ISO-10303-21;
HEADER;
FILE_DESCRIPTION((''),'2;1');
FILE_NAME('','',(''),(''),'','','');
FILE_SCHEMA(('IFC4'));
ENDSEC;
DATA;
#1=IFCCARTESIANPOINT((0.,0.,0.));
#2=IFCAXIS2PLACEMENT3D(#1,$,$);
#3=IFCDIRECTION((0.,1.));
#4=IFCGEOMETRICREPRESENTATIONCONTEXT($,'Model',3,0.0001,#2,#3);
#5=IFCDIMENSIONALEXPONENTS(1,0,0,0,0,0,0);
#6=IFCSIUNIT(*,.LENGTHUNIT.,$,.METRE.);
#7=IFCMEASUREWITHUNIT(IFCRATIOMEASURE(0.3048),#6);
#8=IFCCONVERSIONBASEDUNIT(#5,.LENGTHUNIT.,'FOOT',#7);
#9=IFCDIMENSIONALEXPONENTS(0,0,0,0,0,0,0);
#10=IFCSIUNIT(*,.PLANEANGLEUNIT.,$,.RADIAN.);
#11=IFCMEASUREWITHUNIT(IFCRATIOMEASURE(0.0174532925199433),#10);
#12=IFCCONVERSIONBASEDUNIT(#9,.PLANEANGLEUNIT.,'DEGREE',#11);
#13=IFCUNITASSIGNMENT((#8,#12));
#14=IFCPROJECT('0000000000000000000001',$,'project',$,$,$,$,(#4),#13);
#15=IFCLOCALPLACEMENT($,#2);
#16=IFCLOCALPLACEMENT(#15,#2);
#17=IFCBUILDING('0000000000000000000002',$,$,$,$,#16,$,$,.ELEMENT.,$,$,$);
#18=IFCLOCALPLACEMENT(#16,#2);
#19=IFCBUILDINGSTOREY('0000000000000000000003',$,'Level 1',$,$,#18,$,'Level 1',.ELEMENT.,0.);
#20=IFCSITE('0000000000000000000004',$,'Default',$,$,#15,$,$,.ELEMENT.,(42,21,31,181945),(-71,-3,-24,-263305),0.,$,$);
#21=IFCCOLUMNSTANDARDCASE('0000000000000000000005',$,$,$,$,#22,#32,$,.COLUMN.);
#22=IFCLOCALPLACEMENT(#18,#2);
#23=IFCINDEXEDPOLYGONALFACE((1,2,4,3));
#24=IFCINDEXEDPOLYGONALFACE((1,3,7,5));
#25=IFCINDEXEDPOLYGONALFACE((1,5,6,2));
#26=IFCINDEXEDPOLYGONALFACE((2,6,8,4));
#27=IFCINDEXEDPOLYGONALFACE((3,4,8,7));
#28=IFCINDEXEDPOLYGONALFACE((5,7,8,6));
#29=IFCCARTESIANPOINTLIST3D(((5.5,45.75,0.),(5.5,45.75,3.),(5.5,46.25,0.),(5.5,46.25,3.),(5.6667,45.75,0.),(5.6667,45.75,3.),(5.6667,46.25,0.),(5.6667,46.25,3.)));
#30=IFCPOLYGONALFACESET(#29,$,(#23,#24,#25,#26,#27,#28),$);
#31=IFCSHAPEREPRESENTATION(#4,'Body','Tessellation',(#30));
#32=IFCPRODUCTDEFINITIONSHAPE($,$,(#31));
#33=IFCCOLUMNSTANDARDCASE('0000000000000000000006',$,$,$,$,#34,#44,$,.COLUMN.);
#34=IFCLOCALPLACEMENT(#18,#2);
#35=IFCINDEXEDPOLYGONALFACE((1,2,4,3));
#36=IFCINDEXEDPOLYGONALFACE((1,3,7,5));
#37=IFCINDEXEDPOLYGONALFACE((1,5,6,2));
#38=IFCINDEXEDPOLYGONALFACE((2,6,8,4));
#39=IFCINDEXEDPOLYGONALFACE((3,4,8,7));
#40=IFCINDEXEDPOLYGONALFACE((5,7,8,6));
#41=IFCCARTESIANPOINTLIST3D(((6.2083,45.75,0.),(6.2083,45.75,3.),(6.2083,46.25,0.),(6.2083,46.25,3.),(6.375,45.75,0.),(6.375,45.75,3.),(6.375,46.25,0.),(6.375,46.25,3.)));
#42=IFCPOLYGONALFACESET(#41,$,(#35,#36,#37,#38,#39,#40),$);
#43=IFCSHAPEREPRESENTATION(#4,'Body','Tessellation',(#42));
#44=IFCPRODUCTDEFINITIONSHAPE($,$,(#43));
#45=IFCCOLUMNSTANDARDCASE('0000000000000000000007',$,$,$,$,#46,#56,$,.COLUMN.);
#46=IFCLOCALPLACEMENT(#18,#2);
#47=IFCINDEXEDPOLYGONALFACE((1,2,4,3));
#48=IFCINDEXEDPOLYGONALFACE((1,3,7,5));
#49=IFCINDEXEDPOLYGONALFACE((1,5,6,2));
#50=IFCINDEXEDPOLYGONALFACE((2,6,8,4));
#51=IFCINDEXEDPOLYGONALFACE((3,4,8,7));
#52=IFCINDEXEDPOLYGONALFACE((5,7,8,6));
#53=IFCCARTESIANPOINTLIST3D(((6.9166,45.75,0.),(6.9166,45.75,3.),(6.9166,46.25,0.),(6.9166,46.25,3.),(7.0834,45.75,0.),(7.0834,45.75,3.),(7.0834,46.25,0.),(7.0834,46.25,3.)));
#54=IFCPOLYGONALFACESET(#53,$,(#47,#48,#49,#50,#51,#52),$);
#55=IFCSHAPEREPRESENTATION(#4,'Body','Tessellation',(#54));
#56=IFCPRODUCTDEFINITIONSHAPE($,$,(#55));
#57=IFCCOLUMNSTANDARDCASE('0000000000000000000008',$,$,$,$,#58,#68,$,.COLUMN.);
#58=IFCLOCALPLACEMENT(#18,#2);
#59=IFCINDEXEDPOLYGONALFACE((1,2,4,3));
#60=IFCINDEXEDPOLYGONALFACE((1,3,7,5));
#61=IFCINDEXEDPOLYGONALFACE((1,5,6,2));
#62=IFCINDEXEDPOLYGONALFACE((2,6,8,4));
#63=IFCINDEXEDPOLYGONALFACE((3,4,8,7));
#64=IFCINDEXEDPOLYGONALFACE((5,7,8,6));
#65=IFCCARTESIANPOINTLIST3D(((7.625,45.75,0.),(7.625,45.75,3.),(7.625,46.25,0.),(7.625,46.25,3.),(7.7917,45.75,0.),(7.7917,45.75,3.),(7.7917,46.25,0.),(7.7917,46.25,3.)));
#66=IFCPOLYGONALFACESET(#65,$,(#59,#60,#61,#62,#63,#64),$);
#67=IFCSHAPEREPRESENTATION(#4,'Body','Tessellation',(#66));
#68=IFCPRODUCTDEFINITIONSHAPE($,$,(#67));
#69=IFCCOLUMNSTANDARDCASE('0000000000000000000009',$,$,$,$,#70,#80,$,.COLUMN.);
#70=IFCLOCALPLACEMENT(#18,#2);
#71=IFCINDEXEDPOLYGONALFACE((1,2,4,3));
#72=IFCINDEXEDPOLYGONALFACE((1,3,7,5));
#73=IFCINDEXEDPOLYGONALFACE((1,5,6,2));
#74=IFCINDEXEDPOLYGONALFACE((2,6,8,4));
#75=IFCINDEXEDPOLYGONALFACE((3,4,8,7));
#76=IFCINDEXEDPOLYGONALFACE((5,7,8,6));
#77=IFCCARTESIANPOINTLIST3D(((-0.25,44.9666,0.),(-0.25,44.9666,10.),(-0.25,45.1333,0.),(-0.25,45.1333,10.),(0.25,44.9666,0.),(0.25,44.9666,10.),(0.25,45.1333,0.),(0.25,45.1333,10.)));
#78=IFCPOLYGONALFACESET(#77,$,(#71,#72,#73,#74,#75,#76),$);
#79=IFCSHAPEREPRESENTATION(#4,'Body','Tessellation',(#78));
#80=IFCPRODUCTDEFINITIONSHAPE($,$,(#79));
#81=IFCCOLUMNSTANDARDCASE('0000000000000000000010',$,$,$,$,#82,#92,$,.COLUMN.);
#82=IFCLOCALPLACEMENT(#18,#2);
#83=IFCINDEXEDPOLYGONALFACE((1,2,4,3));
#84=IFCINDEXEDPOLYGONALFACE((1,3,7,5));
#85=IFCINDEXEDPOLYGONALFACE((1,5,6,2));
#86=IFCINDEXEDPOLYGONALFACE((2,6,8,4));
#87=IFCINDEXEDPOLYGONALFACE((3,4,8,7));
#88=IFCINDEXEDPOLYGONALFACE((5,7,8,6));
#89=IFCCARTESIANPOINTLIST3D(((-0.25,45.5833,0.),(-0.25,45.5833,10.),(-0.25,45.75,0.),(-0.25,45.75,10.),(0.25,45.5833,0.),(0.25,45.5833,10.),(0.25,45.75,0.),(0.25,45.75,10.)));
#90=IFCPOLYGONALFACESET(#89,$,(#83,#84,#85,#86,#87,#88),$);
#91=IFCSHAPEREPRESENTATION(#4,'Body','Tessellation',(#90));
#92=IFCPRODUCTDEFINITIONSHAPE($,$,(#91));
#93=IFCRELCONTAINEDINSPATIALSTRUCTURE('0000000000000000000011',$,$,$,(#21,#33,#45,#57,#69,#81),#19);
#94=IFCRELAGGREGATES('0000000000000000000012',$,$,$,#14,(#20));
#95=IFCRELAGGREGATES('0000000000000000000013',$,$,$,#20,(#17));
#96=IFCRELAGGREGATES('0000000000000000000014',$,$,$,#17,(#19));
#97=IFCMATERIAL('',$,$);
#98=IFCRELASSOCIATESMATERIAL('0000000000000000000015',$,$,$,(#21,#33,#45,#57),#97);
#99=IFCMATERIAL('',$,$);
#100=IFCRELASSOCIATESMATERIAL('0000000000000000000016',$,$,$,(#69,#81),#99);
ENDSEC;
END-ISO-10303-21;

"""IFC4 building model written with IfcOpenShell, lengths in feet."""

from ifc_helpers import new_model, entity, si_unit, converted_unit, direction, frame, origin, place, context, project, spatial, rectangle, extrude, material, element, save


model = new_model("IFC4")

# Units and contexts
model_context = context("Model", 3, precision=0.0001, world=origin(), true_north=direction((0.0, 1.0)))
ifc_project = project(units=[converted_unit("LENGTHUNIT", "FOOT", entity("IfcRatioMeasure", 0.3048), si_unit("LENGTHUNIT", "METRE"), dimensions=[1, 0, 0, 0, 0, 0, 0]), converted_unit("PLANEANGLEUNIT", "DEGREE", entity("IfcRatioMeasure", 0.0174532925199433), si_unit("PLANEANGLEUNIT", "RADIAN"), dimensions=[0, 0, 0, 0, 0, 0, 0])], contexts=[model_context])

# Site, building, storey
site_placement = place(None, origin())
site = spatial("IfcSite", under=ifc_project, at=site_placement, Name="Default", CompositionType="ELEMENT", RefLatitude=(42, 21, 31, 181945), RefLongitude=(-71, -3, -24, -263305), RefElevation=0.0)
building_placement = place(site_placement, origin())
building = spatial("IfcBuilding", under=site, at=building_placement, CompositionType="ELEMENT")
storey_placement = place(building_placement, origin())
storey = spatial("IfcBuildingStorey", under=building, at=storey_placement, Name="Level 1", LongName="Level 1", CompositionType="ELEMENT", Elevation=0.0)

# Columns
placement_1 = place(storey_placement, frame((-0.25, 46.0, 0.0)))
ifc_material_1 = material(Name="")
for number, where, z_axis, x_axis in (
    (1, (5.8334, 0.0, 0.0), (0.0, 0.0, 1.0), (1.0, 0.0, 0.0)),
    (2, (6.5417, 0.0, 0.0), (0.0, 0.0, 1.0), (1.0, 0.0, 0.0)),
    (3, (7.25, 0.0, 0.0), (0.0, 0.0, 1.0), (1.0, 0.0, 0.0)),
    (4, (7.9583, 0.0, 0.0), (0.0, 0.0, 1.0), (1.0, 0.0, 0.0)),
):
    element("IfcColumnStandardCase", number, at=place(placement_1, frame(where, z_axis=z_axis, x_axis=x_axis)), inside=storey, material=ifc_material_1, PredefinedType="COLUMN", context=model_context, shape_type="SweptSolid", body=[
        extrude(rectangle(XDim=0.1667, YDim=0.5), origin(), (0.0, 0.0, 1.0), 3.0),
    ])
ifc_material_2 = material(Name="")
placement_2 = place(storey_placement, frame((0.0, -0.25, 0.0), z_axis=(0.0, 0.0, 1.0), x_axis=(0.0, 1.0, 0.0)))
for number, where, z_axis, x_axis in (
    (5, (45.3, 0.0, 0.0), (0.0, 0.0, 1.0), (1.0, 0.0, 0.0)),
    (6, (45.9167, 0.0, 0.0), (0.0, 0.0, 1.0), (1.0, 0.0, 0.0)),
):
    element("IfcColumnStandardCase", number, at=place(placement_2, frame(where, z_axis=z_axis, x_axis=x_axis)), inside=storey, material=ifc_material_2, PredefinedType="COLUMN", context=model_context, shape_type="SweptSolid", body=[
        extrude(rectangle(XDim=0.1667, YDim=0.5), origin(), (0.0, 0.0, 1.0), 10.0),
    ])

save(model, "model.ifc")
